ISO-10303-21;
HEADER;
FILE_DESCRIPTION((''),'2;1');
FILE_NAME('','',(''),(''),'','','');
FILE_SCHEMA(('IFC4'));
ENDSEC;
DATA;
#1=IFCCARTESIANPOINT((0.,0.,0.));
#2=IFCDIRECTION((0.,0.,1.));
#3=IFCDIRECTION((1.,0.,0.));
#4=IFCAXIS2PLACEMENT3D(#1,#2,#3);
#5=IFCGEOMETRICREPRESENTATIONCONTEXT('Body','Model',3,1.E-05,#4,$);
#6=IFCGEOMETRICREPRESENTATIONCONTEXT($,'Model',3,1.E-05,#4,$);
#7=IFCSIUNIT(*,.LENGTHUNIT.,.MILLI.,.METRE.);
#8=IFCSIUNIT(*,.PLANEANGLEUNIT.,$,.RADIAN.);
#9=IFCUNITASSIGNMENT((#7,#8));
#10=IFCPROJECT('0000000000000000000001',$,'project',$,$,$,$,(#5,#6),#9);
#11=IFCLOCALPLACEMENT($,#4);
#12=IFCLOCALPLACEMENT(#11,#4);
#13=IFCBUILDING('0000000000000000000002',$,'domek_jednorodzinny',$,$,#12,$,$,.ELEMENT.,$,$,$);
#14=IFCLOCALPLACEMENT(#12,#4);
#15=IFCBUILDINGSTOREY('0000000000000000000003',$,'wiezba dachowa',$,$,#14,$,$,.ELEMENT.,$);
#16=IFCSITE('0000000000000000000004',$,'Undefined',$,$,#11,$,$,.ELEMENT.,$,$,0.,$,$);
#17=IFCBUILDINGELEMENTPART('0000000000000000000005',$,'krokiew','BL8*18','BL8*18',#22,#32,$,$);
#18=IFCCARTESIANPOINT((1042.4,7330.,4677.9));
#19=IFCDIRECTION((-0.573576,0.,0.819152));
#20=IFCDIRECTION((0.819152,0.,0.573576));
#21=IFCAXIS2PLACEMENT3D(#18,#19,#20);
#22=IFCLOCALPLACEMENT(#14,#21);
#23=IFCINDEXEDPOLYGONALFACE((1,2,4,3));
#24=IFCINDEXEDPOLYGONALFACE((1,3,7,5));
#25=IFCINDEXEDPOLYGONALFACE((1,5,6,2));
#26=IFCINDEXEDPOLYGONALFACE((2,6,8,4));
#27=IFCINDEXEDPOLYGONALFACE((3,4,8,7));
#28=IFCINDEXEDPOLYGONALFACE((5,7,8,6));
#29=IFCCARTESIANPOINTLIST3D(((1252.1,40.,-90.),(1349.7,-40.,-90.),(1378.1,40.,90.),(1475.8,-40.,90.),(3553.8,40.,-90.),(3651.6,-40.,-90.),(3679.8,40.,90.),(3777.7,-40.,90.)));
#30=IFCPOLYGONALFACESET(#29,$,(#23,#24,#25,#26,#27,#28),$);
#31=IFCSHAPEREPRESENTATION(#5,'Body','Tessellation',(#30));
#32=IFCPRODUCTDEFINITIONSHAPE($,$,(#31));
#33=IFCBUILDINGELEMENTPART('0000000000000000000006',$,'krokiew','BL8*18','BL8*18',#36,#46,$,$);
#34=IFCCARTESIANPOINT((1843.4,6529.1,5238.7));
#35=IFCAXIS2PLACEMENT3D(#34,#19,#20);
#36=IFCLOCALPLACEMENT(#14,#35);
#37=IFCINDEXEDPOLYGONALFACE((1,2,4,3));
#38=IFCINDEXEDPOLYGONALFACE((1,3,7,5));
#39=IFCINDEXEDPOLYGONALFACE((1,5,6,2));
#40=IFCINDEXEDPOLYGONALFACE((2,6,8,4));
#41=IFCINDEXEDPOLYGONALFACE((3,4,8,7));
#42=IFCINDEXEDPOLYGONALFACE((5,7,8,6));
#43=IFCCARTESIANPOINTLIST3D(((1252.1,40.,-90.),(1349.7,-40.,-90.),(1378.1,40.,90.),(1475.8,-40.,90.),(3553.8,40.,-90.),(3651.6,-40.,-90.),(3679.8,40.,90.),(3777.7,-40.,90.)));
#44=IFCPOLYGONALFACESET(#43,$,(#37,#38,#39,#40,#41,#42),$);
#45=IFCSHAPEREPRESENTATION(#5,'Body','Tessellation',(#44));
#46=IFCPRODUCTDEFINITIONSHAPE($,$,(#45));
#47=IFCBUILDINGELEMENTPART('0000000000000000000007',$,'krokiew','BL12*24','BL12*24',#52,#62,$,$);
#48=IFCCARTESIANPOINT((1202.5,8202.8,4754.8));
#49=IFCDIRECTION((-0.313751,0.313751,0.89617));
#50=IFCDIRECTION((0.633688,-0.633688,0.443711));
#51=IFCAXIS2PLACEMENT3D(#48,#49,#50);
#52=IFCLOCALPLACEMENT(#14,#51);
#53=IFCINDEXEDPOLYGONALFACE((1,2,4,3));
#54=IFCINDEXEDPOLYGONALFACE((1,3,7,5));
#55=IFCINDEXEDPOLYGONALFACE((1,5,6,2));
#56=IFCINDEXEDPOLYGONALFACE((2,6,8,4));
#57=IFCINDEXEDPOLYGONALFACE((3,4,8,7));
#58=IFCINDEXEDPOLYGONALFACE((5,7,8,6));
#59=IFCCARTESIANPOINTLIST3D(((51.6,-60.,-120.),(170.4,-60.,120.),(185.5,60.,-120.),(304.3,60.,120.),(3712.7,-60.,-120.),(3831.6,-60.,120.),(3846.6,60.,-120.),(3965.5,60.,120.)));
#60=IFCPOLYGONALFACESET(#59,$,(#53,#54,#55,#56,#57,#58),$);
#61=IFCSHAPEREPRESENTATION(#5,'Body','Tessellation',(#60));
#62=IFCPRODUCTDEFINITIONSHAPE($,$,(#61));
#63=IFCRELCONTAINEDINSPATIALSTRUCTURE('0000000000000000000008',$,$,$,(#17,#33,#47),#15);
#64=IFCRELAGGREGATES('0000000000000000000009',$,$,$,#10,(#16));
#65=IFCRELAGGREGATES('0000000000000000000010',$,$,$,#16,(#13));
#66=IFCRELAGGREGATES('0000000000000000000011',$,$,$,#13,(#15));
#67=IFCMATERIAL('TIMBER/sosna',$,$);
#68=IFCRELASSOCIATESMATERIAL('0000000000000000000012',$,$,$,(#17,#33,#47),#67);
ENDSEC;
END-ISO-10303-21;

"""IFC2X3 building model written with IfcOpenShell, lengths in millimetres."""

from ifc_helpers import new_model, si_unit, frame, origin_with_axes, origin_2d_with_axis, place, context, project, spatial, rectangle, extrude, clip, halfspace, material, element, save


model = new_model("IFC2X3")

# Units and contexts
model_context_1 = context("Model", 3, precision=1e-05, world=origin_with_axes(), identifier="Body")
model_context_2 = context("Model", 3, precision=1e-05, world=origin_with_axes())
ifc_project = project(units=[si_unit("LENGTHUNIT", "METRE", prefix="MILLI"), si_unit("PLANEANGLEUNIT", "RADIAN")], contexts=[model_context_1, model_context_2])

# Site, building, storey
site_placement = place(None, origin_with_axes())
site = spatial("IfcSite", under=ifc_project, at=site_placement, Name="Undefined", CompositionType="ELEMENT", RefElevation=0.0)
building_placement = place(site_placement, origin_with_axes())
building = spatial("IfcBuilding", under=site, at=building_placement, Name="domek_jednorodzinny", CompositionType="ELEMENT")
storey_placement = place(building_placement, origin_with_axes())
storey = spatial("IfcBuildingStorey", under=building, at=storey_placement, Name="wiezba dachowa", CompositionType="ELEMENT")

# Building element parts
ifc_material = material(Name="TIMBER/sosna")
for number, where, z_axis, x_axis, name in (
    (1, (1042.4, 7330.0, 4677.9), (-0.573576, 0.0, 0.819152), (0.819152, 0.0, 0.573576), "krokiew"),
    (2, (1843.4, 6529.1, 5238.7), (-0.573576, 0.0, 0.819152), (0.819152, 0.0, 0.573576), "krokiew"),
):
    element("IfcBuildingElementPart", number, at=place(storey_placement, frame(where, z_axis=z_axis, x_axis=x_axis)), inside=storey, material=ifc_material, Name=name, Description="BL8*18", ObjectType="BL8*18", context=model_context_1, shape_type="Clipping", body=[
        clip(clip(extrude(rectangle(XDim=80.0, YDim=180.0, at=origin_2d_with_axis()), frame((5841.8, 0.0, 0.0), z_axis=(-1.0, 0.0, 0.0), x_axis=(0.0, -1.0, 0.0)), (0.0, 0.0, 1.0), 5841.8), halfspace(frame((1349.7, -40.0, -90.0), z_axis=(-0.579227, -0.707107, 0.405581), x_axis=(-0.77359, 0.633686, 0.0)), False)), halfspace(frame((3553.8, 40.0, -90.0), z_axis=(0.578616, 0.707854, -0.405151), x_axis=(0.774245, -0.632886, 0.0)), False)),
    ])
building_element_part_1_placement = place(storey_placement, frame((1202.5, 8202.8, 4754.8), z_axis=(-0.313751, 0.313751, 0.89617), x_axis=(0.633688, -0.633688, 0.443711)))
element("IfcBuildingElementPart", 3, at=building_element_part_1_placement, inside=storey, material=ifc_material, Name="krokiew", Description="BL12*24", ObjectType="BL12*24", context=model_context_1, shape_type="Clipping", body=[
    clip(clip(extrude(rectangle(XDim=120.0, YDim=240.0, at=origin_2d_with_axis()), frame((6720.2, 0.0, 0.0), z_axis=(-1.0, 0.0, 0.0), x_axis=(0.0, -1.0, 0.0)), (0.0, 0.0, 1.0), 6720.2), halfspace(frame((51.6, -60.0, -120.0), z_axis=(-0.633686, 0.707109, 0.31375), x_axis=(0.744711, 0.667387, 0.0)), False)), halfspace(frame((3846.6, 60.0, -120.0), z_axis=(0.633688, -0.707106, -0.313751), x_axis=(-0.74471, -0.667388, 0.0)), False)),
])

save(model, "model.ifc")
